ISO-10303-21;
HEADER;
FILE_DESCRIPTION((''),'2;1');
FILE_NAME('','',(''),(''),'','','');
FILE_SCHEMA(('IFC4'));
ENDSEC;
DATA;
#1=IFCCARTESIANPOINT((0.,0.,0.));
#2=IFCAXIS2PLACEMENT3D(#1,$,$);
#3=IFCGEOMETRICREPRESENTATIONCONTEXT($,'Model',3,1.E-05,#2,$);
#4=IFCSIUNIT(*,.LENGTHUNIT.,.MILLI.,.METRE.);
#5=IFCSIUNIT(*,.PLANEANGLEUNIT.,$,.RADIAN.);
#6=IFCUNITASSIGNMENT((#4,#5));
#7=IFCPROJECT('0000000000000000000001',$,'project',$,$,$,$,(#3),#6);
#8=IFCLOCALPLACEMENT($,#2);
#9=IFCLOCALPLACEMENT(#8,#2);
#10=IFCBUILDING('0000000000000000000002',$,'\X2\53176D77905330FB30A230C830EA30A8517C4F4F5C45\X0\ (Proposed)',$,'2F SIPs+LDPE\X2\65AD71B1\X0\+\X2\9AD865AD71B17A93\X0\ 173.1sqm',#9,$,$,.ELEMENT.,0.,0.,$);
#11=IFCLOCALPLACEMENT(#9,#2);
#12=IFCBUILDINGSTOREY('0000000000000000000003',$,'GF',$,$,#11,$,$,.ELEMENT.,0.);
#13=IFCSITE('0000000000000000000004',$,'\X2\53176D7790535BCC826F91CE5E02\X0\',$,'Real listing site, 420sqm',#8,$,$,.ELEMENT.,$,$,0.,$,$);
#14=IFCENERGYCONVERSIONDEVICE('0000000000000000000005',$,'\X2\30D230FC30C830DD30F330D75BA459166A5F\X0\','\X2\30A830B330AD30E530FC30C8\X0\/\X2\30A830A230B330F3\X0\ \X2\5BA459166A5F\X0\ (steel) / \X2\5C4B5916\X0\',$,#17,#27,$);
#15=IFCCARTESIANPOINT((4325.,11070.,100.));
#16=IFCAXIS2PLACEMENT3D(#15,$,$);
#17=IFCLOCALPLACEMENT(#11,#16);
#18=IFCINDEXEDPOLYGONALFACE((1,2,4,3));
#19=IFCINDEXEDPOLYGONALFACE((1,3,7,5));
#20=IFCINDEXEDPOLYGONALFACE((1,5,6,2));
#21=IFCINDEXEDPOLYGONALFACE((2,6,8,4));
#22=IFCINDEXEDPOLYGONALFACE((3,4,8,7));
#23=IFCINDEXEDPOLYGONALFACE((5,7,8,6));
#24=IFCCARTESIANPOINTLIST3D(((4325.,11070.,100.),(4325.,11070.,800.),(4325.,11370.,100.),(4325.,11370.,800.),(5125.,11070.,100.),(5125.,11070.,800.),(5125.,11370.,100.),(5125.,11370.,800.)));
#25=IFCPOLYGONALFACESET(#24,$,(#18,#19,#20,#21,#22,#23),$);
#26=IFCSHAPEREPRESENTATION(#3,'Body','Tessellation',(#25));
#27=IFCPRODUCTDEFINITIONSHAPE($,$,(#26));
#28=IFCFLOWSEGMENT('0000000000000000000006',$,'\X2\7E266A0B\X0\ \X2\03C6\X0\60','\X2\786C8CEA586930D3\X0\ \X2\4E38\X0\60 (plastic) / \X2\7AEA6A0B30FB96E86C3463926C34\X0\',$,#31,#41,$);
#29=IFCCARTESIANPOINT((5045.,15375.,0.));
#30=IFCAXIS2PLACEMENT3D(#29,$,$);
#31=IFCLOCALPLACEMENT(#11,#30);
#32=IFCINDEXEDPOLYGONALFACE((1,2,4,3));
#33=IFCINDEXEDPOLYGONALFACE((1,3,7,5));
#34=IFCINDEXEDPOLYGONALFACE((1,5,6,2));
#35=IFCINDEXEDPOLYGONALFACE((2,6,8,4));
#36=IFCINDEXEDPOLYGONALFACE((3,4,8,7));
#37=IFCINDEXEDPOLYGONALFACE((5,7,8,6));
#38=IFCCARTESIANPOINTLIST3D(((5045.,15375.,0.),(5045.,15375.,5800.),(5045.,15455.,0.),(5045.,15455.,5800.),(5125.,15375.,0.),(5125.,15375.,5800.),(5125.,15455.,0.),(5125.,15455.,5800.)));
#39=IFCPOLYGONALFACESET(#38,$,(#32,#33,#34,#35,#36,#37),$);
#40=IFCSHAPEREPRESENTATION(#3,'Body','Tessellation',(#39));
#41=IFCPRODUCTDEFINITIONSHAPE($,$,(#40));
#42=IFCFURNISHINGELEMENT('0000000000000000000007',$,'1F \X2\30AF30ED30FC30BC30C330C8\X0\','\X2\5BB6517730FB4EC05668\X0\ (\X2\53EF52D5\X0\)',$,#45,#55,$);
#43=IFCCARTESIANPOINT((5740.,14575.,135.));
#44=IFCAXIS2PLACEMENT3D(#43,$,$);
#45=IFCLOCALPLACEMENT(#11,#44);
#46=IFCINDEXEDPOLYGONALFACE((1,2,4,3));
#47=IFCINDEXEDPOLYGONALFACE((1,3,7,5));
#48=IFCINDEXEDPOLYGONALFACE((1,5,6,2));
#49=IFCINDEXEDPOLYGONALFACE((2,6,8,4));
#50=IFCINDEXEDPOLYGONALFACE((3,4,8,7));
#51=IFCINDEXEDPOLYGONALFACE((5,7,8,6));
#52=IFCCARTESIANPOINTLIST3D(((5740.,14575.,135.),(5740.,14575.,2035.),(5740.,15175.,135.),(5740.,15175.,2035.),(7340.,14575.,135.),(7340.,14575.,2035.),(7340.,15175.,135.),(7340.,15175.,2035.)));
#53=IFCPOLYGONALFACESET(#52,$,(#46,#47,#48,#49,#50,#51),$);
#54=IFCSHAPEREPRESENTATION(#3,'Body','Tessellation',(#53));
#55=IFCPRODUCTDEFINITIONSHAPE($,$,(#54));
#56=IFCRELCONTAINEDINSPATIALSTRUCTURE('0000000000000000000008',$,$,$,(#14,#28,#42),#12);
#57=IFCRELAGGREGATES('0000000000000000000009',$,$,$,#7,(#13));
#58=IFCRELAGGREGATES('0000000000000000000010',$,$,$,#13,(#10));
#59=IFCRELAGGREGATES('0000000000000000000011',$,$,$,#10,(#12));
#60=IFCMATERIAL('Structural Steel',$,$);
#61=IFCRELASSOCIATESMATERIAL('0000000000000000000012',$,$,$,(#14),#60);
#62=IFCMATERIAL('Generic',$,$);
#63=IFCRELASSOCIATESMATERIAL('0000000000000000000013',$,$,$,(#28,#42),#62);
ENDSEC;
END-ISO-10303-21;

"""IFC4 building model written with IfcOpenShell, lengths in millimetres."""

from ifc_helpers import new_model, si_unit, frame, frame_2d, origin, place, context, project, spatial, rectangle, extrude, material, element, save


model = new_model("IFC4")

# Units and contexts
model_context = context("Model", 3, precision=1e-05, world=origin())
ifc_project = project(units=[si_unit("LENGTHUNIT", "METRE", prefix="MILLI"), si_unit("PLANEANGLEUNIT", "RADIAN")], contexts=[model_context])

# Site, building, storey
site_placement = place(None, origin())
site = spatial("IfcSite", under=ifc_project, at=site_placement, Name="北海道富良野市", ObjectType="Real listing site, 420sqm", CompositionType="ELEMENT", RefElevation=0.0)
building_placement = place(site_placement, origin())
building = spatial("IfcBuilding", under=site, at=building_placement, Name="北海道・アトリエ兼住居 (Proposed)", ObjectType="2F SIPs+LDPE断熱+高断熱窓 173.1sqm", CompositionType="ELEMENT", ElevationOfRefHeight=0.0, ElevationOfTerrain=0.0)
storey_placement = place(building_placement, origin())
storey = spatial("IfcBuildingStorey", under=building, at=storey_placement, Name="GF", CompositionType="ELEMENT", Elevation=0.0)

# Shared definitions
ifc_material_1 = material(Name="Generic")

# Energy conversion device
ifc_material_2 = material(Name="Structural Steel")
energy_conversion_device_placement = place(storey_placement, frame((4325.0, 11070.0, 100.0)))
element("IfcEnergyConversionDevice", 1, at=energy_conversion_device_placement, inside=storey, material=ifc_material_2, Name="ヒートポンプ室外機", Description="エコキュート/エアコン 室外機 (steel) / 屋外", context=model_context, shape_type="SweptSolid", body=[
    extrude(rectangle(XDim=800.0, YDim=300.0, at=frame_2d((400.0, 150.0))), frame((4325.0, 11070.0, 100.0)), (0.0, 0.0, 1.0), 700.0),
])

# Flow segment
flow_segment_placement = place(storey_placement, frame((5045.0, 15375.0, 0.0)))
element("IfcFlowSegment", 2, at=flow_segment_placement, inside=storey, material=ifc_material_1, Name="縦樋 φ60", Description="硬質塩ビ 丸60 (plastic) / 竪樋・雨水排水", context=model_context, shape_type="SweptSolid", body=[
    extrude(rectangle(XDim=80.0, YDim=80.0, at=frame_2d((40.0, 40.0))), frame((5045.0, 15375.0, 0.0)), (0.0, 0.0, 1.0), 5800.0),
])

# Furnishing element
furnishing_placement = place(storey_placement, frame((5740.0, 14575.0, 135.0)))
element("IfcFurnishingElement", 3, at=furnishing_placement, inside=storey, material=ifc_material_1, Name="1F クローゼット", Description="家具・什器 (可動)", context=model_context, shape_type="SweptSolid", body=[
    extrude(rectangle(XDim=1600.0, YDim=600.0, at=frame_2d((800.0, 300.0))), frame((5740.0, 14575.0, 135.0)), (0.0, 0.0, 1.0), 1900.0),
])

save(model, "model.ifc")
